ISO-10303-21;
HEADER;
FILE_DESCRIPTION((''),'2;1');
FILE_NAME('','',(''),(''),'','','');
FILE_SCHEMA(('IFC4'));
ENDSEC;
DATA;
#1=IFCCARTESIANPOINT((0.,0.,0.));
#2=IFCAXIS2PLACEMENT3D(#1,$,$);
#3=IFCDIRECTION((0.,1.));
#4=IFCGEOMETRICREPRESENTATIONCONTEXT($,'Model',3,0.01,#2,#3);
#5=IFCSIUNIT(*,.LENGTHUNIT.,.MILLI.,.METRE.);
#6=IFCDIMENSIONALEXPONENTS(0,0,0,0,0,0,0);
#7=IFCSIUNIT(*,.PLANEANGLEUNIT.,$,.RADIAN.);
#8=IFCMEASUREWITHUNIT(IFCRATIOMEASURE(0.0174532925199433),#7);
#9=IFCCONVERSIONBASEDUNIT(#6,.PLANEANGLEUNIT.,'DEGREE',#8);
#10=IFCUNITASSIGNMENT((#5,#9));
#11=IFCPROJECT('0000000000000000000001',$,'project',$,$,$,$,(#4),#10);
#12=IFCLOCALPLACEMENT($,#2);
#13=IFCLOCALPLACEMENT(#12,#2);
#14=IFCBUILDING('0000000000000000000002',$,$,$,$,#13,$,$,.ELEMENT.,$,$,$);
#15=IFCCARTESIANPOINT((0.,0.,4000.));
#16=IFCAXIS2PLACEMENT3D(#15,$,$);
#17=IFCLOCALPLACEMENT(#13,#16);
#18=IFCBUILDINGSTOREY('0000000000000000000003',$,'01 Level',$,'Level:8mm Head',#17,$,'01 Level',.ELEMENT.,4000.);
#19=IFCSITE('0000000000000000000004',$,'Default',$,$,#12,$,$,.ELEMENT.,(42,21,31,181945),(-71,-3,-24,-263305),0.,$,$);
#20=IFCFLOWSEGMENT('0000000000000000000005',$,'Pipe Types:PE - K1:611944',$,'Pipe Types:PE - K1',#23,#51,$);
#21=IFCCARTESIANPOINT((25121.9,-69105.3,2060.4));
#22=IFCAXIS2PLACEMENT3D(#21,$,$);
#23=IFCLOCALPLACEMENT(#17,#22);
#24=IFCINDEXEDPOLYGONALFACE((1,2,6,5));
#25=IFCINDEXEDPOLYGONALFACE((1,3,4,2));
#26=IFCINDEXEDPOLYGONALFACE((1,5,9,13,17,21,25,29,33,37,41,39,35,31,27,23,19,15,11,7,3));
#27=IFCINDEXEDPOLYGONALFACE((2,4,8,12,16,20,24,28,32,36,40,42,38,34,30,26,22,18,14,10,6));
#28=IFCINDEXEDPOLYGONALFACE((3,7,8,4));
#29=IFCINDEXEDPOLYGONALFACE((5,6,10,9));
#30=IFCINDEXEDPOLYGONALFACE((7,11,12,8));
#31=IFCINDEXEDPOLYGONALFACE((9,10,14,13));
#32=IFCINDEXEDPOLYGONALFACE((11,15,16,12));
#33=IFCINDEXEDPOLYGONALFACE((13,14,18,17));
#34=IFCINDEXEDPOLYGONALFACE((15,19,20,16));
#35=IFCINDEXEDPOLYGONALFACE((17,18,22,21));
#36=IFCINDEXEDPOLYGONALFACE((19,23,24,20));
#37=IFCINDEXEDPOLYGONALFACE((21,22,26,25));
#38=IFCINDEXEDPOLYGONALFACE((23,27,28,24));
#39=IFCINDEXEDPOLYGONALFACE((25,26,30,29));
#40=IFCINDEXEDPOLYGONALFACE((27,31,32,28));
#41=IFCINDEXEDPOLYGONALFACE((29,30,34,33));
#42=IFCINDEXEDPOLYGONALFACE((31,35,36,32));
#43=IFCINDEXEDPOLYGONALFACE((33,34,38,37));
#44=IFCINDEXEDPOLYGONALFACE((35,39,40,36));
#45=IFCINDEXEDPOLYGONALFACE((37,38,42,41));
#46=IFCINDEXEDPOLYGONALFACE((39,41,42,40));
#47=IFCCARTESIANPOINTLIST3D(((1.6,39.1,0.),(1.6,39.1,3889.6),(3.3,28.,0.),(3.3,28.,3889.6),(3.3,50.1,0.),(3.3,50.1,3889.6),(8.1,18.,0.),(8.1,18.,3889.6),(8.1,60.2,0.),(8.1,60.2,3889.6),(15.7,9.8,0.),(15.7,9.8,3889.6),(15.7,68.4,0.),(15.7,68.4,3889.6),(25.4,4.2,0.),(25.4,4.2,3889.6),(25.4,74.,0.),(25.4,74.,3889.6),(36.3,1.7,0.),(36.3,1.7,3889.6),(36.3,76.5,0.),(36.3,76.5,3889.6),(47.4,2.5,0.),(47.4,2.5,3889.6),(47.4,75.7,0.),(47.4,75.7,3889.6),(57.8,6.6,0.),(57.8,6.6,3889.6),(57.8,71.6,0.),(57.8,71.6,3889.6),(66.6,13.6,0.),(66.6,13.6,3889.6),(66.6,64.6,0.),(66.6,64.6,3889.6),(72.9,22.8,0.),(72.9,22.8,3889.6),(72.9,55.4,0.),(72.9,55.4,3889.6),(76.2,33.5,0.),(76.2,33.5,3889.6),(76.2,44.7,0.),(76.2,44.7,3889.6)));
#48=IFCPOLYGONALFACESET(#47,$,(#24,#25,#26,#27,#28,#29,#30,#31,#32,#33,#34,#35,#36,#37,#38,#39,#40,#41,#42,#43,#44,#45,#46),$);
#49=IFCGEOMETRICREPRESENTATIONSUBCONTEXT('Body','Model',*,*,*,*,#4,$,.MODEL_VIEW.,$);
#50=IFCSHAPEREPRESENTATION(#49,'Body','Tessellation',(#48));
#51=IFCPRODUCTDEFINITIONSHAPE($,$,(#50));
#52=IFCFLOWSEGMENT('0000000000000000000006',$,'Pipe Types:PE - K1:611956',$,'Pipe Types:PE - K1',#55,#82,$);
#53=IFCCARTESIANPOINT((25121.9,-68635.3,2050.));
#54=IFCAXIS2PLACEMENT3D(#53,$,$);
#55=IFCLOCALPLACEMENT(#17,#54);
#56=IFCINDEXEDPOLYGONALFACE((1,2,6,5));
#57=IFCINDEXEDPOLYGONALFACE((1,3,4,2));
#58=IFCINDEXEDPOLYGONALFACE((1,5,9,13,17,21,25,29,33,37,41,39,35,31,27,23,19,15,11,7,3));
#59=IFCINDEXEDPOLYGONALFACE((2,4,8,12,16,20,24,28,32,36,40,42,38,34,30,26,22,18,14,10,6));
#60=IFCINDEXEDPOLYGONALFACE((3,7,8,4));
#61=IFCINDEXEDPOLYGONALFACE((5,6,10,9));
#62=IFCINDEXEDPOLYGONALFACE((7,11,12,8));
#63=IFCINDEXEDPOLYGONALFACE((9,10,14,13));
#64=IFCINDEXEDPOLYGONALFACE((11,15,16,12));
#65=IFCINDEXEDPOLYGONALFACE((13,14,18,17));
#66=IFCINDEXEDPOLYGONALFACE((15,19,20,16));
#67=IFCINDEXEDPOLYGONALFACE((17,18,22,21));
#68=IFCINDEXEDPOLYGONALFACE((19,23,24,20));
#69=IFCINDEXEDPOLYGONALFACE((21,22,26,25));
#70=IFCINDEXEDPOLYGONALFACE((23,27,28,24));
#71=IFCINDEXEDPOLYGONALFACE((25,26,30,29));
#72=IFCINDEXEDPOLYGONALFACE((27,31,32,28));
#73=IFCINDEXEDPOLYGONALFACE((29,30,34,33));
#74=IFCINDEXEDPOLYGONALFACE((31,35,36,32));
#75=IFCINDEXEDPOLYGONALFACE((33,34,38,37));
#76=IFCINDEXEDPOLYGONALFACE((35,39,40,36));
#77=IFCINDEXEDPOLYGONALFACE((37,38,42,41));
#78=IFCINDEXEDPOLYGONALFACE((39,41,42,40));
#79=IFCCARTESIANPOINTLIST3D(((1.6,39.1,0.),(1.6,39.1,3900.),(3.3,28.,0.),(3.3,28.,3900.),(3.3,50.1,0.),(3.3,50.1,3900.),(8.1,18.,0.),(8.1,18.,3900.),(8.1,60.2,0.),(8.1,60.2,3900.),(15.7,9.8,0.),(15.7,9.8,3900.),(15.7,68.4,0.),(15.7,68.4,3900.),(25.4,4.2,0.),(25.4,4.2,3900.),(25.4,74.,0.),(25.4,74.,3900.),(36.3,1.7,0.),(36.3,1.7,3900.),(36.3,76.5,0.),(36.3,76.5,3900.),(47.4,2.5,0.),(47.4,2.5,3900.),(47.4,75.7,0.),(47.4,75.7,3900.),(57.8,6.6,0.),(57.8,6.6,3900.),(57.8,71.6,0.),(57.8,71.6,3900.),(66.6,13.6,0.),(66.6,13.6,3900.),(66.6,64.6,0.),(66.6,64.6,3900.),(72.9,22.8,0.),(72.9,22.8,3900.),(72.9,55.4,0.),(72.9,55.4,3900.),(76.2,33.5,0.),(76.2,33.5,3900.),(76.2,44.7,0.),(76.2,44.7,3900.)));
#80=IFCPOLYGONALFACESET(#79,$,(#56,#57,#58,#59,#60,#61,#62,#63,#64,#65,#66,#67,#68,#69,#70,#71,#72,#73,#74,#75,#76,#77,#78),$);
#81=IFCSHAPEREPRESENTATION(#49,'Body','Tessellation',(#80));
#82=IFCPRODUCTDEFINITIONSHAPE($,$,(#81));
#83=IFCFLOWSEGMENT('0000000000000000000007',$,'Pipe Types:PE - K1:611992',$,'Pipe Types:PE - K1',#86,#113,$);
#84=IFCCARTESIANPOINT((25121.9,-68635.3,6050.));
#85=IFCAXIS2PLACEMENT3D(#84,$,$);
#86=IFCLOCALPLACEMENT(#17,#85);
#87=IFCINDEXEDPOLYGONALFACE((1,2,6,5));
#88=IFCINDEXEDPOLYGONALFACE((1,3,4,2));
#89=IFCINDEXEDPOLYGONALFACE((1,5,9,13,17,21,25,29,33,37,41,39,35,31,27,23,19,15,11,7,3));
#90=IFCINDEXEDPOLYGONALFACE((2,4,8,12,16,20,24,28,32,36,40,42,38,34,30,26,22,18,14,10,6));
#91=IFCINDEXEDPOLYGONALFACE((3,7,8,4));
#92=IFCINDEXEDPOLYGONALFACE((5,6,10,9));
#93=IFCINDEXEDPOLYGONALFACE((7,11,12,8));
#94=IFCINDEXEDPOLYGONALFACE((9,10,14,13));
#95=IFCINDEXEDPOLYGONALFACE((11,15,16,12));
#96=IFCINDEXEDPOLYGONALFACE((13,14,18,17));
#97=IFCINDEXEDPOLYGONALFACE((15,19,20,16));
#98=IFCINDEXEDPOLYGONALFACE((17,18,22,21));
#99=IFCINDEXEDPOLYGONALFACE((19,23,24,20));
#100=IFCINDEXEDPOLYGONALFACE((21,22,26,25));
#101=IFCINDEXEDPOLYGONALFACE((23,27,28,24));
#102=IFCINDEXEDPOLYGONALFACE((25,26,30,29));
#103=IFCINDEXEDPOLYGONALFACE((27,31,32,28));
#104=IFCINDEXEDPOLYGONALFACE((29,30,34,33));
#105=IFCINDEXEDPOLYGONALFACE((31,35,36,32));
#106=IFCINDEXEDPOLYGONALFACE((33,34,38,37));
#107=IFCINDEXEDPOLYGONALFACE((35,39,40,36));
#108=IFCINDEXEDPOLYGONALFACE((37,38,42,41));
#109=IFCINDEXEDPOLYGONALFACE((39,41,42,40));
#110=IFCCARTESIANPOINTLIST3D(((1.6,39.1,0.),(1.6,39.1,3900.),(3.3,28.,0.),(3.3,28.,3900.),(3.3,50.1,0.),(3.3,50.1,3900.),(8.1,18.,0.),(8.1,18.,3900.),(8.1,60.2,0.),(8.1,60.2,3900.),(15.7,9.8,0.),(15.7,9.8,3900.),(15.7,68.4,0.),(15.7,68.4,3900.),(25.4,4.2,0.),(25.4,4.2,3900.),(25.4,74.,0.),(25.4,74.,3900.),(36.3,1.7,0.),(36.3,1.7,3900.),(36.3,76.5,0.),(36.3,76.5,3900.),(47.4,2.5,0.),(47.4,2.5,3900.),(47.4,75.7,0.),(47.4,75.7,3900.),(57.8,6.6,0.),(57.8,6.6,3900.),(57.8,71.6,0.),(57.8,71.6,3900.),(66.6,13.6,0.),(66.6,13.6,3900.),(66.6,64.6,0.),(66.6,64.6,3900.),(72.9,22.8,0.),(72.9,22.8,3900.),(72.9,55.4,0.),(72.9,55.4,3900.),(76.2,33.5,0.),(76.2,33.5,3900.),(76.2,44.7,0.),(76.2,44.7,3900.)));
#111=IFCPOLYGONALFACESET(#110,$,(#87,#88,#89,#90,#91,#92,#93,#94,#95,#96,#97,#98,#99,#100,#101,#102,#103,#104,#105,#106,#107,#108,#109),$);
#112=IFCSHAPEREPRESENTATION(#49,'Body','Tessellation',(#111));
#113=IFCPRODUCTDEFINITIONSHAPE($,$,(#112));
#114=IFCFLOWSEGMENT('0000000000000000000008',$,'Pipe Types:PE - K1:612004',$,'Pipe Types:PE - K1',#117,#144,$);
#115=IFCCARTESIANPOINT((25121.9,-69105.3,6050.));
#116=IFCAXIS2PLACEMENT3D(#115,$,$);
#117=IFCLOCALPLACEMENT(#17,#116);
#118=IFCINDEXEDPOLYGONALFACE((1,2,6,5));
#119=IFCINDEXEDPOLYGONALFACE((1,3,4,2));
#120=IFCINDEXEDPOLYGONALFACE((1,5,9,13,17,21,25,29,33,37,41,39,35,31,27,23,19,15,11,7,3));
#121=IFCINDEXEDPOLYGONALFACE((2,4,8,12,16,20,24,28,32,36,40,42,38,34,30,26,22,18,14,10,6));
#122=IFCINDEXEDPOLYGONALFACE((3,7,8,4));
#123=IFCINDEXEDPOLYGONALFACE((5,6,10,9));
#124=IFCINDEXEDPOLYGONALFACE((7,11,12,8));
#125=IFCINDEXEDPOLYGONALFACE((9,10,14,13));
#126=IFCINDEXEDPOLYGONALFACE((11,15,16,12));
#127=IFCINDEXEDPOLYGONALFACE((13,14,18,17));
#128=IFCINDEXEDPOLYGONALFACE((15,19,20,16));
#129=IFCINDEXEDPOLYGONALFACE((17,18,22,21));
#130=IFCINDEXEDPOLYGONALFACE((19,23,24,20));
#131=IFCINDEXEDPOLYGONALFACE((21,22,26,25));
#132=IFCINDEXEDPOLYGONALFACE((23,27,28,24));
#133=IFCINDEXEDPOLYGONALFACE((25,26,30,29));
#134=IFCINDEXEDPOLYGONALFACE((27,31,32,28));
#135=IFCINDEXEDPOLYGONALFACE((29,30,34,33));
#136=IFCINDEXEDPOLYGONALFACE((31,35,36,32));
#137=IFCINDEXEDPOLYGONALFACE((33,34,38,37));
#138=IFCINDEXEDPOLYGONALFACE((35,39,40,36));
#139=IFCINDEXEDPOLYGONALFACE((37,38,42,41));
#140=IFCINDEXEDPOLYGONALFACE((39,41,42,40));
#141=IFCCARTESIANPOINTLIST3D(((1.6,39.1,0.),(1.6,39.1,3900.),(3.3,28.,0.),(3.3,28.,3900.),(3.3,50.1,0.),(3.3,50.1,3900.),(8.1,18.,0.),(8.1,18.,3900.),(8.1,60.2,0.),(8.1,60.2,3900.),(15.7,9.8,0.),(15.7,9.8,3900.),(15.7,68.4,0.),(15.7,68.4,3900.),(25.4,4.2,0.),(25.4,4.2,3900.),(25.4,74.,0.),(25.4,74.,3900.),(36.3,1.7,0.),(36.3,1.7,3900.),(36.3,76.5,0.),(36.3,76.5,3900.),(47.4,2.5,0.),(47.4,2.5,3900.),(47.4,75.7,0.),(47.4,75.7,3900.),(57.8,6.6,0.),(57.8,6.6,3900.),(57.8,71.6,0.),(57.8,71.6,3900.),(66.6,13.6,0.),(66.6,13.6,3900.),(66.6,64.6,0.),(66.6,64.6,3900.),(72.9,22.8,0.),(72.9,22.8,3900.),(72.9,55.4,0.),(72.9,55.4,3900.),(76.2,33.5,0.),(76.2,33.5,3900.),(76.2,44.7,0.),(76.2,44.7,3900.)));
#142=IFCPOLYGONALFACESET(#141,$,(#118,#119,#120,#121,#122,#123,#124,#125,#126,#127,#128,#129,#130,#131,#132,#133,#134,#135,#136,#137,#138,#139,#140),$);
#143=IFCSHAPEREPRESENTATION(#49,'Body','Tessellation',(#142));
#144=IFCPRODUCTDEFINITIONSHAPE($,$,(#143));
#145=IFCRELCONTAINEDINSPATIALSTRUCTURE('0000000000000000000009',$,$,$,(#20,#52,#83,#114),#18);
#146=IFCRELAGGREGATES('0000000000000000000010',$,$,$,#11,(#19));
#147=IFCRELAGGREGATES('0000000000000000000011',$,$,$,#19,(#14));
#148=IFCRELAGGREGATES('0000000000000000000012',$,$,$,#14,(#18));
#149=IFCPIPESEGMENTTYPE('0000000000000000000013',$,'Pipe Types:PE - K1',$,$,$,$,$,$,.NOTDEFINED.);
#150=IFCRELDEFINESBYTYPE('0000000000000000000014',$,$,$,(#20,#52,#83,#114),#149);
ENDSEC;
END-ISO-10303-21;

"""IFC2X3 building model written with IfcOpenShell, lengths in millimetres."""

from ifc_helpers import new_model, entity, si_unit, converted_unit, direction, frame, origin, origin_2d_with_axis, place, context, subcontext, project, spatial, circle, extrude, type_object, element, save


model = new_model("IFC2X3")

# Units and contexts
model_context = context("Model", 3, precision=0.01, world=origin(), true_north=direction((0.0, 1.0)))
body_context = subcontext(model_context, "Body", "Model", "MODEL_VIEW")
ifc_project = project(units=[si_unit("LENGTHUNIT", "METRE", prefix="MILLI"), converted_unit("PLANEANGLEUNIT", "DEGREE", entity("IfcRatioMeasure", 0.0174532925199433), si_unit("PLANEANGLEUNIT", "RADIAN"), dimensions=[0, 0, 0, 0, 0, 0, 0])], contexts=[model_context])

# Site, building, storey
site_placement = place(None, origin())
site = spatial("IfcSite", under=ifc_project, at=site_placement, Name="Default", CompositionType="ELEMENT", RefLatitude=(42, 21, 31, 181945), RefLongitude=(-71, -3, -24, -263305), RefElevation=0.0)
building_placement = place(site_placement, origin())
building = spatial("IfcBuilding", under=site, at=building_placement, CompositionType="ELEMENT")
storey_placement = place(building_placement, frame((0.0, 0.0, 4000.0)))
storey = spatial("IfcBuildingStorey", under=building, at=storey_placement, Name="01 Level", ObjectType="Level:8mm Head", LongName="01 Level", CompositionType="ELEMENT", Elevation=4000.0)

# Flow segments
pipe_segment_type_1 = type_object("IfcPipeSegmentType", Name="Pipe Types:PE - K1", PredefinedType="NOTDEFINED")
flow_segment_1_placement = place(storey_placement, frame((25121.9, -69105.3, 2060.4)))
element("IfcFlowSegment", 1, at=flow_segment_1_placement, inside=storey, type_object=pipe_segment_type_1, Name="Pipe Types:PE - K1:611944", ObjectType="Pipe Types:PE - K1", context=body_context, shape_type="SweptSolid", body=[
    extrude(circle(Radius=37.5, at=origin_2d_with_axis()), frame((39.1, 39.1, 0.0), z_axis=(0.0, 0.0, 1.0), x_axis=(-1.0, 0.0, 0.0)), (0.0, 0.0, 1.0), 3889.6),
])
for number, where, name in (
    (2, (25121.9, -68635.3, 2050.0), "Pipe Types:PE - K1:611956"),
    (3, (25121.9, -68635.3, 6050.0), "Pipe Types:PE - K1:611992"),
    (4, (25121.9, -69105.3, 6050.0), "Pipe Types:PE - K1:612004"),
):
    element("IfcFlowSegment", number, at=place(storey_placement, frame(where)), inside=storey, type_object=pipe_segment_type_1, Name=name, ObjectType="Pipe Types:PE - K1", context=body_context, shape_type="SweptSolid", body=[
        extrude(circle(Radius=37.5, at=origin_2d_with_axis()), frame((39.1, 39.1, 0.0), z_axis=(0.0, 0.0, 1.0), x_axis=(-1.0, 0.0, 0.0)), (0.0, 0.0, 1.0), 3900.0),
    ])

save(model, "model.ifc")
